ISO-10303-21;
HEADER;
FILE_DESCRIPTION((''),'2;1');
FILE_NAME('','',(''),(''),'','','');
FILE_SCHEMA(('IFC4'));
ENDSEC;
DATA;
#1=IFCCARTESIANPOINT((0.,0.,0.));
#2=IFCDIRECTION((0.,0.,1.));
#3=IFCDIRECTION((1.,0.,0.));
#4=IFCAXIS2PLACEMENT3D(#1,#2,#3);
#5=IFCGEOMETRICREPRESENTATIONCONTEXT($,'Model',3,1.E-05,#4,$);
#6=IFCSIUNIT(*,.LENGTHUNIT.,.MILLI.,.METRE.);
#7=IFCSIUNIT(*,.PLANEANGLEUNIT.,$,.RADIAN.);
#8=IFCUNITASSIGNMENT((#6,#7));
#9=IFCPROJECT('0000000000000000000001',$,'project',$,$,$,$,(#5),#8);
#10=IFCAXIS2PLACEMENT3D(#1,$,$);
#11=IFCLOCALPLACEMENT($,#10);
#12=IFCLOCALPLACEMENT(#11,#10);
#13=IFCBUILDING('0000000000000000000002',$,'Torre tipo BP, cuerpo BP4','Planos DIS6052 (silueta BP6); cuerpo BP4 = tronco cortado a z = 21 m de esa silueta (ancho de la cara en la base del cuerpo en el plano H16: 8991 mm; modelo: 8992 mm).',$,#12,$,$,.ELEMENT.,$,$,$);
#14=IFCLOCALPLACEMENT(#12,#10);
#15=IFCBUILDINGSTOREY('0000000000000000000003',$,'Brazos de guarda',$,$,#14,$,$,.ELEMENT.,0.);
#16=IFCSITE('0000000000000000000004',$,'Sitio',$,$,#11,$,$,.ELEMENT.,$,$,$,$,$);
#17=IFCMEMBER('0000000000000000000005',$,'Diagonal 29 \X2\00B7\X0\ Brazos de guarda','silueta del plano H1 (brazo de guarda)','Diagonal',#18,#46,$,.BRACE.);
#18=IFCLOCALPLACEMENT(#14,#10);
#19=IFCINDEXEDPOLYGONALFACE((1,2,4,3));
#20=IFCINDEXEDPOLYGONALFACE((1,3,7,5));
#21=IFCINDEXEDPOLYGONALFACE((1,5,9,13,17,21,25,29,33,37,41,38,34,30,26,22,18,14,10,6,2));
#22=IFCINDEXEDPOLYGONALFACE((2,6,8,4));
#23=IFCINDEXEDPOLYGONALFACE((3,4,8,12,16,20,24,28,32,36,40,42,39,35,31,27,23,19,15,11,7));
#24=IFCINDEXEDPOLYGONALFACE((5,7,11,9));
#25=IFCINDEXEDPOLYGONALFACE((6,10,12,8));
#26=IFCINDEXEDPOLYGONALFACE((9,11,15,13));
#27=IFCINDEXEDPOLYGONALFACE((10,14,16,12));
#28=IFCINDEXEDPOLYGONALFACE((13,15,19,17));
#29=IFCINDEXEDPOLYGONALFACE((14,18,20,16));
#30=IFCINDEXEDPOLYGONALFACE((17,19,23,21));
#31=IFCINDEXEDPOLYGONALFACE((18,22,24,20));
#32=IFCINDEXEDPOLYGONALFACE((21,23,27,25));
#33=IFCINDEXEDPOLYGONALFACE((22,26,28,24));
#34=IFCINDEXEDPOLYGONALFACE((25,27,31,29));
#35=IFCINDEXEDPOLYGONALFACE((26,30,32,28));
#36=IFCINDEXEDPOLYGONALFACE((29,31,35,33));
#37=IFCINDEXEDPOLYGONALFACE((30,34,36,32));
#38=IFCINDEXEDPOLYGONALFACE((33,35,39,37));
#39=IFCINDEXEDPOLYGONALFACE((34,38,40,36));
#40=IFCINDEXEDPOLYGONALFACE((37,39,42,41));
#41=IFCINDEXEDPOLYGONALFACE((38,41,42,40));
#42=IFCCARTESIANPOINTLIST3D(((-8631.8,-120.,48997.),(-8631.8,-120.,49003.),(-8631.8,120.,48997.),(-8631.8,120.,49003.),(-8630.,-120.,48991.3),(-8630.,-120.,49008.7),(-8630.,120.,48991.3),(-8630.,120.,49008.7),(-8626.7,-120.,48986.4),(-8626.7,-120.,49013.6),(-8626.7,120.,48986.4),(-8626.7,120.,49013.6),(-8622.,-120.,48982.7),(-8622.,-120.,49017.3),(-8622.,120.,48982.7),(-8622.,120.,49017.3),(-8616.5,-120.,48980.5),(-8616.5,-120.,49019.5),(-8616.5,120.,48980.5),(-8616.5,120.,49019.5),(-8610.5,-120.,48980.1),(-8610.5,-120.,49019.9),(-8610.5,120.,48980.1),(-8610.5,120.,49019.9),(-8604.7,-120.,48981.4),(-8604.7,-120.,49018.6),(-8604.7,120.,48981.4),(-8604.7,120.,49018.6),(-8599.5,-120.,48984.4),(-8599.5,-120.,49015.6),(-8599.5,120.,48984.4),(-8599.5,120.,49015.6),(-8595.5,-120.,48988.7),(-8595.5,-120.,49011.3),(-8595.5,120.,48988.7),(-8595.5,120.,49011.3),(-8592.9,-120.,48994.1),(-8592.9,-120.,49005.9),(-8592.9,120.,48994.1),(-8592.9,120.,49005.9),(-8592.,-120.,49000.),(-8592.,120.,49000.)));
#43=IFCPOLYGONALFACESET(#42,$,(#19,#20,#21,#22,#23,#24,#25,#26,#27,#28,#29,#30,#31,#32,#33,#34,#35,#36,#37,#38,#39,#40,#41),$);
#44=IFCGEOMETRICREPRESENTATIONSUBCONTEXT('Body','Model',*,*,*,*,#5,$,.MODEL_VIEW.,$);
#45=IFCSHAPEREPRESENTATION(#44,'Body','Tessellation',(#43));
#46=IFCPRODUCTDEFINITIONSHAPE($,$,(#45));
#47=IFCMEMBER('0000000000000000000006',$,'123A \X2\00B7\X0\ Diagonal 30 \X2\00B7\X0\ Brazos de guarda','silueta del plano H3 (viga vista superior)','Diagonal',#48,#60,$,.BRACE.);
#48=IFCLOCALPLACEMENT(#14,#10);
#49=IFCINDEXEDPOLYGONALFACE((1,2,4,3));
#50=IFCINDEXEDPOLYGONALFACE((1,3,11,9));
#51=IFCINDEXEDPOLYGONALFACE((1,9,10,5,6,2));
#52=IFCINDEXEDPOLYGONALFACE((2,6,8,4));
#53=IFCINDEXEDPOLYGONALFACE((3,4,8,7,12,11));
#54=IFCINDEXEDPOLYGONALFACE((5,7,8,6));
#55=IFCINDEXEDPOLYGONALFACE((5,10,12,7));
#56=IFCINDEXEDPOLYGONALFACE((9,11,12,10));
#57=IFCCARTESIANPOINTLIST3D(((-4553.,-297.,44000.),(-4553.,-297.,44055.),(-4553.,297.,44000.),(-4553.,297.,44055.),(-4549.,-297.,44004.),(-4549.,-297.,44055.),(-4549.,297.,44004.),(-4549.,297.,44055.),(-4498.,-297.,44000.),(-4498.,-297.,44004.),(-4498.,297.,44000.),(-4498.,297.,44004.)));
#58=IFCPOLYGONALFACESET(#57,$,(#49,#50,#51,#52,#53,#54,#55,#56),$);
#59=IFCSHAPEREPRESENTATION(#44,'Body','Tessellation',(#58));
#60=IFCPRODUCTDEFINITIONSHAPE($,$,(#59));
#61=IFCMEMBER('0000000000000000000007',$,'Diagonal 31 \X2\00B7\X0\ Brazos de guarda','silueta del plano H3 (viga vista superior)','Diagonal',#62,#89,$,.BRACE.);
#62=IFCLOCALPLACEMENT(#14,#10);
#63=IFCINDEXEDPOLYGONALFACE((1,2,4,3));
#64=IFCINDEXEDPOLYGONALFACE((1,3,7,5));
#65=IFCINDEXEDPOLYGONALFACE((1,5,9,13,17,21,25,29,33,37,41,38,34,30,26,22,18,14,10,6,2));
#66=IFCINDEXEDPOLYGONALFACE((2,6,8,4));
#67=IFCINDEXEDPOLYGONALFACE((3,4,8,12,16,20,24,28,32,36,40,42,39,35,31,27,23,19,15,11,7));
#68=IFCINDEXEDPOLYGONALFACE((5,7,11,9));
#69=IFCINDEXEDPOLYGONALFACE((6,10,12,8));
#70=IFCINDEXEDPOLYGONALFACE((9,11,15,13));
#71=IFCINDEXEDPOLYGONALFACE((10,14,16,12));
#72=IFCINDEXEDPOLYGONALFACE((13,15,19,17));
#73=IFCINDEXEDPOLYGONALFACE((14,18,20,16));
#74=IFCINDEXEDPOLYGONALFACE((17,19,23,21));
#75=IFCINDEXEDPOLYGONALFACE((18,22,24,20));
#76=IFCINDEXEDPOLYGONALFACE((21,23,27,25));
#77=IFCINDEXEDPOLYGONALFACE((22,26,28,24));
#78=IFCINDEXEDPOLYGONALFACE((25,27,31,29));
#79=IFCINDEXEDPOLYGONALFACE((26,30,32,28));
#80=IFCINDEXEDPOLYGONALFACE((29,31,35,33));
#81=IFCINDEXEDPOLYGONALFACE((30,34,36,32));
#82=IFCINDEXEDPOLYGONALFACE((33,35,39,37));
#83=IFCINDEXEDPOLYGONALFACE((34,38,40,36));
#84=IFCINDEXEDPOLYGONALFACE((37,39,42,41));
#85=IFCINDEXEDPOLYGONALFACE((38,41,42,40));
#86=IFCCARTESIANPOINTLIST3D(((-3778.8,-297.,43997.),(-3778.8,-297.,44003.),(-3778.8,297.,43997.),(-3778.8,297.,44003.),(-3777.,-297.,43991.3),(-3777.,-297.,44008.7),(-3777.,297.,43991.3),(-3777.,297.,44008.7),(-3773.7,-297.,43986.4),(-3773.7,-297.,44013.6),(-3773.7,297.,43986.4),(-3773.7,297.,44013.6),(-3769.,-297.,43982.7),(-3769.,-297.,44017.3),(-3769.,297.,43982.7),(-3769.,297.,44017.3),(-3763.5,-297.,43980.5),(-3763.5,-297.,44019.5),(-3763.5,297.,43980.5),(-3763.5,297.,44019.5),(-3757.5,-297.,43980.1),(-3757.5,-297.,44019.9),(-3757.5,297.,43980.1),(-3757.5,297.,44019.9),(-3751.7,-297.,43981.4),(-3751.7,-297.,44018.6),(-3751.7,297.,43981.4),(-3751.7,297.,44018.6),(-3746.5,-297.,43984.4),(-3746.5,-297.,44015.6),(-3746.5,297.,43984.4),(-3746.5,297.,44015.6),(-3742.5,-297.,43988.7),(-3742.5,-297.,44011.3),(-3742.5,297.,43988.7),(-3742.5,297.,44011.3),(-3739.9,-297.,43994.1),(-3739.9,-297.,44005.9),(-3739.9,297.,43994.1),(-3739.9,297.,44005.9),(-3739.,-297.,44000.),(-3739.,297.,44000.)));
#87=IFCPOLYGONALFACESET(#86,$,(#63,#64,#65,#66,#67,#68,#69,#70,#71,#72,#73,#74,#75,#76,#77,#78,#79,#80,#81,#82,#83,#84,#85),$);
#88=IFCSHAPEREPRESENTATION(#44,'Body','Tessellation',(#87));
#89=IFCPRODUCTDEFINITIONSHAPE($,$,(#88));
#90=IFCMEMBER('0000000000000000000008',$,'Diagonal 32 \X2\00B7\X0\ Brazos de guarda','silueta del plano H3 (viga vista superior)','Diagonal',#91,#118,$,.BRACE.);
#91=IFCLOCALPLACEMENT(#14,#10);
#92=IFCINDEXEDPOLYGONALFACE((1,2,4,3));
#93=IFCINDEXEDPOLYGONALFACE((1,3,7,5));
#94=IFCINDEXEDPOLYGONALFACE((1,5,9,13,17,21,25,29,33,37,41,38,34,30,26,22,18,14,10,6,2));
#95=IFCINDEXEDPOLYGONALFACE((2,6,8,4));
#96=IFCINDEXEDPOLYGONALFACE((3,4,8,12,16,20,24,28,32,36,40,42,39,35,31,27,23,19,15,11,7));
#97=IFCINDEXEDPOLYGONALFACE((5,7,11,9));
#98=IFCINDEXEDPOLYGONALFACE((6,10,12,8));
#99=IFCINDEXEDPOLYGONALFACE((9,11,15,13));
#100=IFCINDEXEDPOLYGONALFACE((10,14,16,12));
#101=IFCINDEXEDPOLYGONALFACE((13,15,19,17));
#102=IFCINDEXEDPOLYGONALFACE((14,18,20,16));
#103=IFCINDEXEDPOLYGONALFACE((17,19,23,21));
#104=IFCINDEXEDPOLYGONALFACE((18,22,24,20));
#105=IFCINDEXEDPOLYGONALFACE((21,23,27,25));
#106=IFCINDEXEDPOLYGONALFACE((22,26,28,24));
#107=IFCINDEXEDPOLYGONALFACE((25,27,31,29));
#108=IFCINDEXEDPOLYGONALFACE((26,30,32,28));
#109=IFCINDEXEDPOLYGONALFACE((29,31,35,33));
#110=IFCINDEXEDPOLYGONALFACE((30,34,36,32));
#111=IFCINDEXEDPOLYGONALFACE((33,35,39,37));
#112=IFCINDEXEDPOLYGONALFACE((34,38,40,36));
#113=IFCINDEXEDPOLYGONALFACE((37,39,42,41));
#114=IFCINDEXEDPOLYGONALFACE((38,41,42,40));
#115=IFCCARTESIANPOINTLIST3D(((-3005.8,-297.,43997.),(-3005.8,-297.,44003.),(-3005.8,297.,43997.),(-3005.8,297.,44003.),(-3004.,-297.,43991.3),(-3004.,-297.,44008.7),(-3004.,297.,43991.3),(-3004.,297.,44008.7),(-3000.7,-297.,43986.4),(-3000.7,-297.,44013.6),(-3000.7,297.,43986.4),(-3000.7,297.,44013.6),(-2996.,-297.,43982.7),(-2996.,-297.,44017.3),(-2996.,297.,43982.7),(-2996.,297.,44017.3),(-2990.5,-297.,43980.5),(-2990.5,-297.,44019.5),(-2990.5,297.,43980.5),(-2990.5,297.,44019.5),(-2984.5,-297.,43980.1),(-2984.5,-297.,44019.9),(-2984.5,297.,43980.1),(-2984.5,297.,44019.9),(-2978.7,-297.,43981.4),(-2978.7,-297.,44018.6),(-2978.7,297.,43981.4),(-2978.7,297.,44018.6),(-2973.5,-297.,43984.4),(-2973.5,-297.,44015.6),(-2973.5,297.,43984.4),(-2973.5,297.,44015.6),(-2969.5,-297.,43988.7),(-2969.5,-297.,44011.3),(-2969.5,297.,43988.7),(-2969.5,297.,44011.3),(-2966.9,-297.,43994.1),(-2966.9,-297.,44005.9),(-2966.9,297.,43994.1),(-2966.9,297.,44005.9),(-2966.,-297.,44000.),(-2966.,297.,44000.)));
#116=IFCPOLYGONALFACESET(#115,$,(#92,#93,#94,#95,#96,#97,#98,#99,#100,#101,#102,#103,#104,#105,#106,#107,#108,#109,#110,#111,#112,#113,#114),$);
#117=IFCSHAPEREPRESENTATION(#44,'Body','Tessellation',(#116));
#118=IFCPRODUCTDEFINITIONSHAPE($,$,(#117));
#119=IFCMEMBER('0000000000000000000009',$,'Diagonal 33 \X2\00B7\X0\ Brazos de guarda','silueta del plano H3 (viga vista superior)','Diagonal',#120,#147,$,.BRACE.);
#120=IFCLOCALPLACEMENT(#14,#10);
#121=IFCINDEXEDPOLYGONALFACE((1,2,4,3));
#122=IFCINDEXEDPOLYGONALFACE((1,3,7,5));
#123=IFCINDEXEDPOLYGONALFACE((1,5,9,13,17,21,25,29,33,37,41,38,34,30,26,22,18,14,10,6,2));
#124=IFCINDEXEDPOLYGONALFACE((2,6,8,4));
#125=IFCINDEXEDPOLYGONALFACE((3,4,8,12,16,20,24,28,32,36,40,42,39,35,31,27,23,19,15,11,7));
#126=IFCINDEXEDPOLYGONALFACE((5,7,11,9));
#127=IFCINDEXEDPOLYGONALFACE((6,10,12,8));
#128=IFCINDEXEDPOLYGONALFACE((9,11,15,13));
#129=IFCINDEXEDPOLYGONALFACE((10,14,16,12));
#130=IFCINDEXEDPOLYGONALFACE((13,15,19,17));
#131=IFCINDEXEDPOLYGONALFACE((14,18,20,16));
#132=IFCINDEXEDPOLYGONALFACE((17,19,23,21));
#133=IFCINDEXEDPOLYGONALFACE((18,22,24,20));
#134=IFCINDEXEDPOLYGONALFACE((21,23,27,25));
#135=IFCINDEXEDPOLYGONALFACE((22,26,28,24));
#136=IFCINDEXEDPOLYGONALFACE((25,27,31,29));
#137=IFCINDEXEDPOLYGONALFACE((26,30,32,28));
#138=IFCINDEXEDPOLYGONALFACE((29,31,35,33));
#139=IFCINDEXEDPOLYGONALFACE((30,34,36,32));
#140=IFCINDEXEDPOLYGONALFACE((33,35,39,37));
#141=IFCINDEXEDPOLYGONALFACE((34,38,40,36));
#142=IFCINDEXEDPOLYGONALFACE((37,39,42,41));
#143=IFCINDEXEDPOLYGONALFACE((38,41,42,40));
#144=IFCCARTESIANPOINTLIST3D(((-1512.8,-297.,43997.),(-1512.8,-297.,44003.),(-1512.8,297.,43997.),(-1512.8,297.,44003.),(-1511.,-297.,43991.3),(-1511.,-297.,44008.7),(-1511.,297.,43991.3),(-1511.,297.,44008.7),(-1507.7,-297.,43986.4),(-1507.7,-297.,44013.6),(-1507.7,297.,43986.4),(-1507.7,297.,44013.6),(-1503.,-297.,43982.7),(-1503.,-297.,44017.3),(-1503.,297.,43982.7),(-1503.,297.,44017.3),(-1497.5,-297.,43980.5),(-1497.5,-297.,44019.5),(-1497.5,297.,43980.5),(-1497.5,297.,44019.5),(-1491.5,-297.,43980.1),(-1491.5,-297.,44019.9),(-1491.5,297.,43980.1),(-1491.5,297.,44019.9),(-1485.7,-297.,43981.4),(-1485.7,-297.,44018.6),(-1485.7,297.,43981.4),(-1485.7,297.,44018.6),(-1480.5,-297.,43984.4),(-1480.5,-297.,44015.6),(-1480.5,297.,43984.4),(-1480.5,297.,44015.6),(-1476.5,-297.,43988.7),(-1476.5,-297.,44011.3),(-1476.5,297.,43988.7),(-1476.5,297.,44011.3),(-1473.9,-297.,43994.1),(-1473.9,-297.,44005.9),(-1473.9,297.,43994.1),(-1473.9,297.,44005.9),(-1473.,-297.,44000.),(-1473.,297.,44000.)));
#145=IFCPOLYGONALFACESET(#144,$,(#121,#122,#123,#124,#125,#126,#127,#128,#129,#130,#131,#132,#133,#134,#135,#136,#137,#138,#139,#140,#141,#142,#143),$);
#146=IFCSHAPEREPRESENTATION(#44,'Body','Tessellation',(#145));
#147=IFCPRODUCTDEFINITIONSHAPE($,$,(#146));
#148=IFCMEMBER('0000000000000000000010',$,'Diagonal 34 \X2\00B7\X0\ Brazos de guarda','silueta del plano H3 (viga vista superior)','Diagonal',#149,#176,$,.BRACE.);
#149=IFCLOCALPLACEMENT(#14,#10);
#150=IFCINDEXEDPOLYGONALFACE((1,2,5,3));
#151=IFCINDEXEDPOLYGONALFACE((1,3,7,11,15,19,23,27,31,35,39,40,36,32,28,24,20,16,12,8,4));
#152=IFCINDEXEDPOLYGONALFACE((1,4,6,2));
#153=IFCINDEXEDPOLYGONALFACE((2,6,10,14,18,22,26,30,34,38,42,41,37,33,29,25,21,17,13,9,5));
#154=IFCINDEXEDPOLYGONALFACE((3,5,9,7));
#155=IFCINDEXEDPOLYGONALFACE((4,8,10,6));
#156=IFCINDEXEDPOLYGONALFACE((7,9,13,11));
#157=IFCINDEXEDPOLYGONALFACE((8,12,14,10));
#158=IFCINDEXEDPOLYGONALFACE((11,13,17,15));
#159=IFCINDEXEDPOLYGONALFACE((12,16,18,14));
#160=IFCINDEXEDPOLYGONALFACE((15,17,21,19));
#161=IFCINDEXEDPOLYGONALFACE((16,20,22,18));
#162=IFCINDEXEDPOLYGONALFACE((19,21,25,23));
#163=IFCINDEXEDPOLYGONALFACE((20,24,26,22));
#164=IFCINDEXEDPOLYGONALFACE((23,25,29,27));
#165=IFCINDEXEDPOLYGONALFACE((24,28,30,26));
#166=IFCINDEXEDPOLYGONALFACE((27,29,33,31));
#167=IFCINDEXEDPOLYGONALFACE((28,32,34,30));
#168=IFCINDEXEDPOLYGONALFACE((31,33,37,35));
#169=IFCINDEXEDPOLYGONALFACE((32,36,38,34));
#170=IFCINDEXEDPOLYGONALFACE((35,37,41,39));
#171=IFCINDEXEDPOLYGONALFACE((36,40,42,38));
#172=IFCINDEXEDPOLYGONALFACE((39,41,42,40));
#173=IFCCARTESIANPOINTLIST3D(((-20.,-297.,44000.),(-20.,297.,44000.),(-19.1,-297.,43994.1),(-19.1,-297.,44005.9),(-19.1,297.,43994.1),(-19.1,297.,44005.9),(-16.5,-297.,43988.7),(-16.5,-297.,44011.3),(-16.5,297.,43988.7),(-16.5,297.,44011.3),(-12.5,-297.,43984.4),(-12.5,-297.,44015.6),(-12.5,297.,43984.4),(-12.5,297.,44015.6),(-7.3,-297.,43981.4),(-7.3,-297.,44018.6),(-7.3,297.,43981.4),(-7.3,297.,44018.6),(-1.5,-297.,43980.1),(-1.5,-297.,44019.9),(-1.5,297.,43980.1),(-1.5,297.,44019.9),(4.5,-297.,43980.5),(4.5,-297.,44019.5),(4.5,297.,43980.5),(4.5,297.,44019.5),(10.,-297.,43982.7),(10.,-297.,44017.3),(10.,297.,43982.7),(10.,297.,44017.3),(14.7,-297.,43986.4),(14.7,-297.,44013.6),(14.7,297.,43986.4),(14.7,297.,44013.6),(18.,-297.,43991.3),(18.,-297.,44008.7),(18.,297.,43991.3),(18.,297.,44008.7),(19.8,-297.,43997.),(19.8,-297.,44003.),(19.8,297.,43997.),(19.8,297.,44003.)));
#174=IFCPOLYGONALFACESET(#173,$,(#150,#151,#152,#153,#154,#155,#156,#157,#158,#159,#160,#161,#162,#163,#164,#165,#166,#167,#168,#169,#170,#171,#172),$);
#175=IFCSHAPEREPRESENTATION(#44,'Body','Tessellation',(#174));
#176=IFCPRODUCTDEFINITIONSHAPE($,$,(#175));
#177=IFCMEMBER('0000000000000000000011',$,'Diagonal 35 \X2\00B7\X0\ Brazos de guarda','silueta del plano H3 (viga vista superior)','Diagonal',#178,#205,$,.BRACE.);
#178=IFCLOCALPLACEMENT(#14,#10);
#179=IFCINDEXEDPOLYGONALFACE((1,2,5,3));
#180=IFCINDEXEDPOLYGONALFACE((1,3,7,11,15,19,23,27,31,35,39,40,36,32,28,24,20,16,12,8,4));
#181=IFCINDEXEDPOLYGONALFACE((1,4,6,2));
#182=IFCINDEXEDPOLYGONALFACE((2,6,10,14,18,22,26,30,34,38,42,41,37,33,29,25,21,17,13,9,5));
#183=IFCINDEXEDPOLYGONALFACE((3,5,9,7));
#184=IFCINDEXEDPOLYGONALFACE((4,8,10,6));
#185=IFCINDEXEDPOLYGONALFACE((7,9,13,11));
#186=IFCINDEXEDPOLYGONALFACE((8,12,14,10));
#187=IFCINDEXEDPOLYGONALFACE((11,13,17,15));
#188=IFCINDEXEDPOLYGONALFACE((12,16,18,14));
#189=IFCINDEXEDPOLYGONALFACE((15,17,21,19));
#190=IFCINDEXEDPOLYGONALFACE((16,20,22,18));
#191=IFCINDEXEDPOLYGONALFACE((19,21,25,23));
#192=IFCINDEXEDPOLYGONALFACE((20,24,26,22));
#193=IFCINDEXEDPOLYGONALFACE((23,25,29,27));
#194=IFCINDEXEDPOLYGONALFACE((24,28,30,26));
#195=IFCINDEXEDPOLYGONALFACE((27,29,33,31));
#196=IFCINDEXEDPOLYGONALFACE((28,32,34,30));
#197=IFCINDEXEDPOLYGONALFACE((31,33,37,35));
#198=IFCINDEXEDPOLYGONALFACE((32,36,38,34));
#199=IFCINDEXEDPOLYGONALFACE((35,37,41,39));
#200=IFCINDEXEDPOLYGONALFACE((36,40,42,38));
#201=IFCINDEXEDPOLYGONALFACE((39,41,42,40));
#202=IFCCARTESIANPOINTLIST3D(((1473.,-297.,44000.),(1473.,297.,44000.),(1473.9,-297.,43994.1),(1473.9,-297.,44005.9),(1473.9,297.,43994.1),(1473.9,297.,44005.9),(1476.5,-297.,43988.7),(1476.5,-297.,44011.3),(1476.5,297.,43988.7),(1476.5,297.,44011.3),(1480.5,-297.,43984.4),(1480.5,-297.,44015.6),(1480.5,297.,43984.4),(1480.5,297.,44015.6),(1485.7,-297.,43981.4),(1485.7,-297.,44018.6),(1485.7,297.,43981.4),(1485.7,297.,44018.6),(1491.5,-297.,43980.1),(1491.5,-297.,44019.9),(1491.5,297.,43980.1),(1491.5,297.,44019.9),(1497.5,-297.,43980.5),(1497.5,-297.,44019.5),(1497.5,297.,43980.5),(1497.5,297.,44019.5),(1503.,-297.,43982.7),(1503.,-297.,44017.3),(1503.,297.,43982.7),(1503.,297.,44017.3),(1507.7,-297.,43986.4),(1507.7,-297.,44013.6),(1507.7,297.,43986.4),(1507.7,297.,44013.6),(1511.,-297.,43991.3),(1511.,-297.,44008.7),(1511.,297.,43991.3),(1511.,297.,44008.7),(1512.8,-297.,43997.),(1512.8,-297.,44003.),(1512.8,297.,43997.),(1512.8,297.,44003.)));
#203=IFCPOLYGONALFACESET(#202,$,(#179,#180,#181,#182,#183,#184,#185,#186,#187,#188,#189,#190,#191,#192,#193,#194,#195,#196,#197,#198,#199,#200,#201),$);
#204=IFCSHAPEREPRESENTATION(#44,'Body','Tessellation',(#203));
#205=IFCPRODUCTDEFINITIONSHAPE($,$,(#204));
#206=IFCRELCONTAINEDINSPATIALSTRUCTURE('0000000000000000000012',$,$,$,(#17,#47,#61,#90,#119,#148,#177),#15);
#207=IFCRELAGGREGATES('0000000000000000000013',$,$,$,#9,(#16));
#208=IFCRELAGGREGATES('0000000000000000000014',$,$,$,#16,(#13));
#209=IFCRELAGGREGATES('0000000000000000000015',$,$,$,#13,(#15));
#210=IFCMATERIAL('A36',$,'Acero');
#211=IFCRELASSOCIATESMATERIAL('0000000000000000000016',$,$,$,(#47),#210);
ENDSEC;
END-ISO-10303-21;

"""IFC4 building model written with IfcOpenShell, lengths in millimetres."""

from ifc_helpers import new_model, si_unit, frame, frame_2d, origin, origin_with_axes, place, context, subcontext, project, spatial, circle, l_section, extrude, material, element, save


model = new_model("IFC4")

# Units and contexts
model_context = context("Model", 3, precision=1e-05, world=origin_with_axes())
body_context = subcontext(model_context, "Body", "Model", "MODEL_VIEW")
ifc_project = project(units=[si_unit("LENGTHUNIT", "METRE", prefix="MILLI"), si_unit("PLANEANGLEUNIT", "RADIAN")], contexts=[model_context])

# Site, building, storey
site_placement = place(None, origin())
site = spatial("IfcSite", under=ifc_project, at=site_placement, Name="Sitio", CompositionType="ELEMENT")
building_placement = place(site_placement, origin())
building = spatial("IfcBuilding", under=site, at=building_placement, Name="Torre tipo BP, cuerpo BP4", Description="Planos DIS6052 (silueta BP6); cuerpo BP4 = tronco cortado a z = 21 m de esa silueta (ancho de la cara en la base del cuerpo en el plano H16: 8991 mm; modelo: 8992 mm).", CompositionType="ELEMENT")
storey_placement = place(building_placement, origin())
storey = spatial("IfcBuildingStorey", under=building, at=storey_placement, Name="Brazos de guarda", CompositionType="ELEMENT", Elevation=0.0)

# Members
member_1_placement = place(storey_placement, frame((-8612.0, 120.0, 49000.0), z_axis=(0.0, -1.0, 0.0), x_axis=(1.0, 0.0, 0.0)))
element("IfcMember", 1, at=member_1_placement, inside=storey, Name="Diagonal 29 · Brazos de guarda", Description="silueta del plano H1 (brazo de guarda)", ObjectType="Diagonal", PredefinedType="BRACE", context=body_context, shape_type="SweptSolid", body=[
    extrude(circle(Radius=20.0), None, (0.0, 0.0, 1.0), 240.0),
])
ifc_material = material(Name="A36", Category="Acero")
member_2_placement = place(storey_placement, frame((-4553.0, 297.0, 44000.0), z_axis=(0.0, -1.0, 0.0), x_axis=(1.0, 0.0, 0.0)))
element("IfcMember", 2, at=member_2_placement, inside=storey, material=ifc_material, Name="123A · Diagonal 30 · Brazos de guarda", Description="silueta del plano H3 (viga vista superior)", ObjectType="Diagonal", PredefinedType="BRACE", context=body_context, shape_type="SweptSolid", body=[
    extrude(l_section(Depth=55.0, Width=55.0, Thickness=4.0, at=frame_2d((27.5, 27.5))), None, (0.0, 0.0, 1.0), 594.0),
])
for number, where, z_axis, x_axis, name in (
    (3, (-3759.0, 297.0, 44000.0), (0.0, -1.0, 0.0), (1.0, 0.0, 0.0), "Diagonal 31 · Brazos de guarda"),
    (4, (-2986.0, 297.0, 44000.0), (0.0, -1.0, 0.0), (1.0, 0.0, 0.0), "Diagonal 32 · Brazos de guarda"),
    (5, (-1493.0, 297.0, 44000.0), (0.0, -1.0, 0.0), (1.0, 0.0, 0.0), "Diagonal 33 · Brazos de guarda"),
    (6, (0.0, 297.0, 44000.0), (0.0, -1.0, 0.0), (-1.0, 0.0, 0.0), "Diagonal 34 · Brazos de guarda"),
    (7, (1493.0, 297.0, 44000.0), (0.0, -1.0, 0.0), (-1.0, 0.0, 0.0), "Diagonal 35 · Brazos de guarda"),
):
    element("IfcMember", number, at=place(storey_placement, frame(where, z_axis=z_axis, x_axis=x_axis)), inside=storey, Name=name, Description="silueta del plano H3 (viga vista superior)", ObjectType="Diagonal", PredefinedType="BRACE", context=body_context, shape_type="SweptSolid", body=[
        extrude(circle(Radius=20.0), None, (0.0, 0.0, 1.0), 594.0),
    ])

save(model, "model.ifc")
